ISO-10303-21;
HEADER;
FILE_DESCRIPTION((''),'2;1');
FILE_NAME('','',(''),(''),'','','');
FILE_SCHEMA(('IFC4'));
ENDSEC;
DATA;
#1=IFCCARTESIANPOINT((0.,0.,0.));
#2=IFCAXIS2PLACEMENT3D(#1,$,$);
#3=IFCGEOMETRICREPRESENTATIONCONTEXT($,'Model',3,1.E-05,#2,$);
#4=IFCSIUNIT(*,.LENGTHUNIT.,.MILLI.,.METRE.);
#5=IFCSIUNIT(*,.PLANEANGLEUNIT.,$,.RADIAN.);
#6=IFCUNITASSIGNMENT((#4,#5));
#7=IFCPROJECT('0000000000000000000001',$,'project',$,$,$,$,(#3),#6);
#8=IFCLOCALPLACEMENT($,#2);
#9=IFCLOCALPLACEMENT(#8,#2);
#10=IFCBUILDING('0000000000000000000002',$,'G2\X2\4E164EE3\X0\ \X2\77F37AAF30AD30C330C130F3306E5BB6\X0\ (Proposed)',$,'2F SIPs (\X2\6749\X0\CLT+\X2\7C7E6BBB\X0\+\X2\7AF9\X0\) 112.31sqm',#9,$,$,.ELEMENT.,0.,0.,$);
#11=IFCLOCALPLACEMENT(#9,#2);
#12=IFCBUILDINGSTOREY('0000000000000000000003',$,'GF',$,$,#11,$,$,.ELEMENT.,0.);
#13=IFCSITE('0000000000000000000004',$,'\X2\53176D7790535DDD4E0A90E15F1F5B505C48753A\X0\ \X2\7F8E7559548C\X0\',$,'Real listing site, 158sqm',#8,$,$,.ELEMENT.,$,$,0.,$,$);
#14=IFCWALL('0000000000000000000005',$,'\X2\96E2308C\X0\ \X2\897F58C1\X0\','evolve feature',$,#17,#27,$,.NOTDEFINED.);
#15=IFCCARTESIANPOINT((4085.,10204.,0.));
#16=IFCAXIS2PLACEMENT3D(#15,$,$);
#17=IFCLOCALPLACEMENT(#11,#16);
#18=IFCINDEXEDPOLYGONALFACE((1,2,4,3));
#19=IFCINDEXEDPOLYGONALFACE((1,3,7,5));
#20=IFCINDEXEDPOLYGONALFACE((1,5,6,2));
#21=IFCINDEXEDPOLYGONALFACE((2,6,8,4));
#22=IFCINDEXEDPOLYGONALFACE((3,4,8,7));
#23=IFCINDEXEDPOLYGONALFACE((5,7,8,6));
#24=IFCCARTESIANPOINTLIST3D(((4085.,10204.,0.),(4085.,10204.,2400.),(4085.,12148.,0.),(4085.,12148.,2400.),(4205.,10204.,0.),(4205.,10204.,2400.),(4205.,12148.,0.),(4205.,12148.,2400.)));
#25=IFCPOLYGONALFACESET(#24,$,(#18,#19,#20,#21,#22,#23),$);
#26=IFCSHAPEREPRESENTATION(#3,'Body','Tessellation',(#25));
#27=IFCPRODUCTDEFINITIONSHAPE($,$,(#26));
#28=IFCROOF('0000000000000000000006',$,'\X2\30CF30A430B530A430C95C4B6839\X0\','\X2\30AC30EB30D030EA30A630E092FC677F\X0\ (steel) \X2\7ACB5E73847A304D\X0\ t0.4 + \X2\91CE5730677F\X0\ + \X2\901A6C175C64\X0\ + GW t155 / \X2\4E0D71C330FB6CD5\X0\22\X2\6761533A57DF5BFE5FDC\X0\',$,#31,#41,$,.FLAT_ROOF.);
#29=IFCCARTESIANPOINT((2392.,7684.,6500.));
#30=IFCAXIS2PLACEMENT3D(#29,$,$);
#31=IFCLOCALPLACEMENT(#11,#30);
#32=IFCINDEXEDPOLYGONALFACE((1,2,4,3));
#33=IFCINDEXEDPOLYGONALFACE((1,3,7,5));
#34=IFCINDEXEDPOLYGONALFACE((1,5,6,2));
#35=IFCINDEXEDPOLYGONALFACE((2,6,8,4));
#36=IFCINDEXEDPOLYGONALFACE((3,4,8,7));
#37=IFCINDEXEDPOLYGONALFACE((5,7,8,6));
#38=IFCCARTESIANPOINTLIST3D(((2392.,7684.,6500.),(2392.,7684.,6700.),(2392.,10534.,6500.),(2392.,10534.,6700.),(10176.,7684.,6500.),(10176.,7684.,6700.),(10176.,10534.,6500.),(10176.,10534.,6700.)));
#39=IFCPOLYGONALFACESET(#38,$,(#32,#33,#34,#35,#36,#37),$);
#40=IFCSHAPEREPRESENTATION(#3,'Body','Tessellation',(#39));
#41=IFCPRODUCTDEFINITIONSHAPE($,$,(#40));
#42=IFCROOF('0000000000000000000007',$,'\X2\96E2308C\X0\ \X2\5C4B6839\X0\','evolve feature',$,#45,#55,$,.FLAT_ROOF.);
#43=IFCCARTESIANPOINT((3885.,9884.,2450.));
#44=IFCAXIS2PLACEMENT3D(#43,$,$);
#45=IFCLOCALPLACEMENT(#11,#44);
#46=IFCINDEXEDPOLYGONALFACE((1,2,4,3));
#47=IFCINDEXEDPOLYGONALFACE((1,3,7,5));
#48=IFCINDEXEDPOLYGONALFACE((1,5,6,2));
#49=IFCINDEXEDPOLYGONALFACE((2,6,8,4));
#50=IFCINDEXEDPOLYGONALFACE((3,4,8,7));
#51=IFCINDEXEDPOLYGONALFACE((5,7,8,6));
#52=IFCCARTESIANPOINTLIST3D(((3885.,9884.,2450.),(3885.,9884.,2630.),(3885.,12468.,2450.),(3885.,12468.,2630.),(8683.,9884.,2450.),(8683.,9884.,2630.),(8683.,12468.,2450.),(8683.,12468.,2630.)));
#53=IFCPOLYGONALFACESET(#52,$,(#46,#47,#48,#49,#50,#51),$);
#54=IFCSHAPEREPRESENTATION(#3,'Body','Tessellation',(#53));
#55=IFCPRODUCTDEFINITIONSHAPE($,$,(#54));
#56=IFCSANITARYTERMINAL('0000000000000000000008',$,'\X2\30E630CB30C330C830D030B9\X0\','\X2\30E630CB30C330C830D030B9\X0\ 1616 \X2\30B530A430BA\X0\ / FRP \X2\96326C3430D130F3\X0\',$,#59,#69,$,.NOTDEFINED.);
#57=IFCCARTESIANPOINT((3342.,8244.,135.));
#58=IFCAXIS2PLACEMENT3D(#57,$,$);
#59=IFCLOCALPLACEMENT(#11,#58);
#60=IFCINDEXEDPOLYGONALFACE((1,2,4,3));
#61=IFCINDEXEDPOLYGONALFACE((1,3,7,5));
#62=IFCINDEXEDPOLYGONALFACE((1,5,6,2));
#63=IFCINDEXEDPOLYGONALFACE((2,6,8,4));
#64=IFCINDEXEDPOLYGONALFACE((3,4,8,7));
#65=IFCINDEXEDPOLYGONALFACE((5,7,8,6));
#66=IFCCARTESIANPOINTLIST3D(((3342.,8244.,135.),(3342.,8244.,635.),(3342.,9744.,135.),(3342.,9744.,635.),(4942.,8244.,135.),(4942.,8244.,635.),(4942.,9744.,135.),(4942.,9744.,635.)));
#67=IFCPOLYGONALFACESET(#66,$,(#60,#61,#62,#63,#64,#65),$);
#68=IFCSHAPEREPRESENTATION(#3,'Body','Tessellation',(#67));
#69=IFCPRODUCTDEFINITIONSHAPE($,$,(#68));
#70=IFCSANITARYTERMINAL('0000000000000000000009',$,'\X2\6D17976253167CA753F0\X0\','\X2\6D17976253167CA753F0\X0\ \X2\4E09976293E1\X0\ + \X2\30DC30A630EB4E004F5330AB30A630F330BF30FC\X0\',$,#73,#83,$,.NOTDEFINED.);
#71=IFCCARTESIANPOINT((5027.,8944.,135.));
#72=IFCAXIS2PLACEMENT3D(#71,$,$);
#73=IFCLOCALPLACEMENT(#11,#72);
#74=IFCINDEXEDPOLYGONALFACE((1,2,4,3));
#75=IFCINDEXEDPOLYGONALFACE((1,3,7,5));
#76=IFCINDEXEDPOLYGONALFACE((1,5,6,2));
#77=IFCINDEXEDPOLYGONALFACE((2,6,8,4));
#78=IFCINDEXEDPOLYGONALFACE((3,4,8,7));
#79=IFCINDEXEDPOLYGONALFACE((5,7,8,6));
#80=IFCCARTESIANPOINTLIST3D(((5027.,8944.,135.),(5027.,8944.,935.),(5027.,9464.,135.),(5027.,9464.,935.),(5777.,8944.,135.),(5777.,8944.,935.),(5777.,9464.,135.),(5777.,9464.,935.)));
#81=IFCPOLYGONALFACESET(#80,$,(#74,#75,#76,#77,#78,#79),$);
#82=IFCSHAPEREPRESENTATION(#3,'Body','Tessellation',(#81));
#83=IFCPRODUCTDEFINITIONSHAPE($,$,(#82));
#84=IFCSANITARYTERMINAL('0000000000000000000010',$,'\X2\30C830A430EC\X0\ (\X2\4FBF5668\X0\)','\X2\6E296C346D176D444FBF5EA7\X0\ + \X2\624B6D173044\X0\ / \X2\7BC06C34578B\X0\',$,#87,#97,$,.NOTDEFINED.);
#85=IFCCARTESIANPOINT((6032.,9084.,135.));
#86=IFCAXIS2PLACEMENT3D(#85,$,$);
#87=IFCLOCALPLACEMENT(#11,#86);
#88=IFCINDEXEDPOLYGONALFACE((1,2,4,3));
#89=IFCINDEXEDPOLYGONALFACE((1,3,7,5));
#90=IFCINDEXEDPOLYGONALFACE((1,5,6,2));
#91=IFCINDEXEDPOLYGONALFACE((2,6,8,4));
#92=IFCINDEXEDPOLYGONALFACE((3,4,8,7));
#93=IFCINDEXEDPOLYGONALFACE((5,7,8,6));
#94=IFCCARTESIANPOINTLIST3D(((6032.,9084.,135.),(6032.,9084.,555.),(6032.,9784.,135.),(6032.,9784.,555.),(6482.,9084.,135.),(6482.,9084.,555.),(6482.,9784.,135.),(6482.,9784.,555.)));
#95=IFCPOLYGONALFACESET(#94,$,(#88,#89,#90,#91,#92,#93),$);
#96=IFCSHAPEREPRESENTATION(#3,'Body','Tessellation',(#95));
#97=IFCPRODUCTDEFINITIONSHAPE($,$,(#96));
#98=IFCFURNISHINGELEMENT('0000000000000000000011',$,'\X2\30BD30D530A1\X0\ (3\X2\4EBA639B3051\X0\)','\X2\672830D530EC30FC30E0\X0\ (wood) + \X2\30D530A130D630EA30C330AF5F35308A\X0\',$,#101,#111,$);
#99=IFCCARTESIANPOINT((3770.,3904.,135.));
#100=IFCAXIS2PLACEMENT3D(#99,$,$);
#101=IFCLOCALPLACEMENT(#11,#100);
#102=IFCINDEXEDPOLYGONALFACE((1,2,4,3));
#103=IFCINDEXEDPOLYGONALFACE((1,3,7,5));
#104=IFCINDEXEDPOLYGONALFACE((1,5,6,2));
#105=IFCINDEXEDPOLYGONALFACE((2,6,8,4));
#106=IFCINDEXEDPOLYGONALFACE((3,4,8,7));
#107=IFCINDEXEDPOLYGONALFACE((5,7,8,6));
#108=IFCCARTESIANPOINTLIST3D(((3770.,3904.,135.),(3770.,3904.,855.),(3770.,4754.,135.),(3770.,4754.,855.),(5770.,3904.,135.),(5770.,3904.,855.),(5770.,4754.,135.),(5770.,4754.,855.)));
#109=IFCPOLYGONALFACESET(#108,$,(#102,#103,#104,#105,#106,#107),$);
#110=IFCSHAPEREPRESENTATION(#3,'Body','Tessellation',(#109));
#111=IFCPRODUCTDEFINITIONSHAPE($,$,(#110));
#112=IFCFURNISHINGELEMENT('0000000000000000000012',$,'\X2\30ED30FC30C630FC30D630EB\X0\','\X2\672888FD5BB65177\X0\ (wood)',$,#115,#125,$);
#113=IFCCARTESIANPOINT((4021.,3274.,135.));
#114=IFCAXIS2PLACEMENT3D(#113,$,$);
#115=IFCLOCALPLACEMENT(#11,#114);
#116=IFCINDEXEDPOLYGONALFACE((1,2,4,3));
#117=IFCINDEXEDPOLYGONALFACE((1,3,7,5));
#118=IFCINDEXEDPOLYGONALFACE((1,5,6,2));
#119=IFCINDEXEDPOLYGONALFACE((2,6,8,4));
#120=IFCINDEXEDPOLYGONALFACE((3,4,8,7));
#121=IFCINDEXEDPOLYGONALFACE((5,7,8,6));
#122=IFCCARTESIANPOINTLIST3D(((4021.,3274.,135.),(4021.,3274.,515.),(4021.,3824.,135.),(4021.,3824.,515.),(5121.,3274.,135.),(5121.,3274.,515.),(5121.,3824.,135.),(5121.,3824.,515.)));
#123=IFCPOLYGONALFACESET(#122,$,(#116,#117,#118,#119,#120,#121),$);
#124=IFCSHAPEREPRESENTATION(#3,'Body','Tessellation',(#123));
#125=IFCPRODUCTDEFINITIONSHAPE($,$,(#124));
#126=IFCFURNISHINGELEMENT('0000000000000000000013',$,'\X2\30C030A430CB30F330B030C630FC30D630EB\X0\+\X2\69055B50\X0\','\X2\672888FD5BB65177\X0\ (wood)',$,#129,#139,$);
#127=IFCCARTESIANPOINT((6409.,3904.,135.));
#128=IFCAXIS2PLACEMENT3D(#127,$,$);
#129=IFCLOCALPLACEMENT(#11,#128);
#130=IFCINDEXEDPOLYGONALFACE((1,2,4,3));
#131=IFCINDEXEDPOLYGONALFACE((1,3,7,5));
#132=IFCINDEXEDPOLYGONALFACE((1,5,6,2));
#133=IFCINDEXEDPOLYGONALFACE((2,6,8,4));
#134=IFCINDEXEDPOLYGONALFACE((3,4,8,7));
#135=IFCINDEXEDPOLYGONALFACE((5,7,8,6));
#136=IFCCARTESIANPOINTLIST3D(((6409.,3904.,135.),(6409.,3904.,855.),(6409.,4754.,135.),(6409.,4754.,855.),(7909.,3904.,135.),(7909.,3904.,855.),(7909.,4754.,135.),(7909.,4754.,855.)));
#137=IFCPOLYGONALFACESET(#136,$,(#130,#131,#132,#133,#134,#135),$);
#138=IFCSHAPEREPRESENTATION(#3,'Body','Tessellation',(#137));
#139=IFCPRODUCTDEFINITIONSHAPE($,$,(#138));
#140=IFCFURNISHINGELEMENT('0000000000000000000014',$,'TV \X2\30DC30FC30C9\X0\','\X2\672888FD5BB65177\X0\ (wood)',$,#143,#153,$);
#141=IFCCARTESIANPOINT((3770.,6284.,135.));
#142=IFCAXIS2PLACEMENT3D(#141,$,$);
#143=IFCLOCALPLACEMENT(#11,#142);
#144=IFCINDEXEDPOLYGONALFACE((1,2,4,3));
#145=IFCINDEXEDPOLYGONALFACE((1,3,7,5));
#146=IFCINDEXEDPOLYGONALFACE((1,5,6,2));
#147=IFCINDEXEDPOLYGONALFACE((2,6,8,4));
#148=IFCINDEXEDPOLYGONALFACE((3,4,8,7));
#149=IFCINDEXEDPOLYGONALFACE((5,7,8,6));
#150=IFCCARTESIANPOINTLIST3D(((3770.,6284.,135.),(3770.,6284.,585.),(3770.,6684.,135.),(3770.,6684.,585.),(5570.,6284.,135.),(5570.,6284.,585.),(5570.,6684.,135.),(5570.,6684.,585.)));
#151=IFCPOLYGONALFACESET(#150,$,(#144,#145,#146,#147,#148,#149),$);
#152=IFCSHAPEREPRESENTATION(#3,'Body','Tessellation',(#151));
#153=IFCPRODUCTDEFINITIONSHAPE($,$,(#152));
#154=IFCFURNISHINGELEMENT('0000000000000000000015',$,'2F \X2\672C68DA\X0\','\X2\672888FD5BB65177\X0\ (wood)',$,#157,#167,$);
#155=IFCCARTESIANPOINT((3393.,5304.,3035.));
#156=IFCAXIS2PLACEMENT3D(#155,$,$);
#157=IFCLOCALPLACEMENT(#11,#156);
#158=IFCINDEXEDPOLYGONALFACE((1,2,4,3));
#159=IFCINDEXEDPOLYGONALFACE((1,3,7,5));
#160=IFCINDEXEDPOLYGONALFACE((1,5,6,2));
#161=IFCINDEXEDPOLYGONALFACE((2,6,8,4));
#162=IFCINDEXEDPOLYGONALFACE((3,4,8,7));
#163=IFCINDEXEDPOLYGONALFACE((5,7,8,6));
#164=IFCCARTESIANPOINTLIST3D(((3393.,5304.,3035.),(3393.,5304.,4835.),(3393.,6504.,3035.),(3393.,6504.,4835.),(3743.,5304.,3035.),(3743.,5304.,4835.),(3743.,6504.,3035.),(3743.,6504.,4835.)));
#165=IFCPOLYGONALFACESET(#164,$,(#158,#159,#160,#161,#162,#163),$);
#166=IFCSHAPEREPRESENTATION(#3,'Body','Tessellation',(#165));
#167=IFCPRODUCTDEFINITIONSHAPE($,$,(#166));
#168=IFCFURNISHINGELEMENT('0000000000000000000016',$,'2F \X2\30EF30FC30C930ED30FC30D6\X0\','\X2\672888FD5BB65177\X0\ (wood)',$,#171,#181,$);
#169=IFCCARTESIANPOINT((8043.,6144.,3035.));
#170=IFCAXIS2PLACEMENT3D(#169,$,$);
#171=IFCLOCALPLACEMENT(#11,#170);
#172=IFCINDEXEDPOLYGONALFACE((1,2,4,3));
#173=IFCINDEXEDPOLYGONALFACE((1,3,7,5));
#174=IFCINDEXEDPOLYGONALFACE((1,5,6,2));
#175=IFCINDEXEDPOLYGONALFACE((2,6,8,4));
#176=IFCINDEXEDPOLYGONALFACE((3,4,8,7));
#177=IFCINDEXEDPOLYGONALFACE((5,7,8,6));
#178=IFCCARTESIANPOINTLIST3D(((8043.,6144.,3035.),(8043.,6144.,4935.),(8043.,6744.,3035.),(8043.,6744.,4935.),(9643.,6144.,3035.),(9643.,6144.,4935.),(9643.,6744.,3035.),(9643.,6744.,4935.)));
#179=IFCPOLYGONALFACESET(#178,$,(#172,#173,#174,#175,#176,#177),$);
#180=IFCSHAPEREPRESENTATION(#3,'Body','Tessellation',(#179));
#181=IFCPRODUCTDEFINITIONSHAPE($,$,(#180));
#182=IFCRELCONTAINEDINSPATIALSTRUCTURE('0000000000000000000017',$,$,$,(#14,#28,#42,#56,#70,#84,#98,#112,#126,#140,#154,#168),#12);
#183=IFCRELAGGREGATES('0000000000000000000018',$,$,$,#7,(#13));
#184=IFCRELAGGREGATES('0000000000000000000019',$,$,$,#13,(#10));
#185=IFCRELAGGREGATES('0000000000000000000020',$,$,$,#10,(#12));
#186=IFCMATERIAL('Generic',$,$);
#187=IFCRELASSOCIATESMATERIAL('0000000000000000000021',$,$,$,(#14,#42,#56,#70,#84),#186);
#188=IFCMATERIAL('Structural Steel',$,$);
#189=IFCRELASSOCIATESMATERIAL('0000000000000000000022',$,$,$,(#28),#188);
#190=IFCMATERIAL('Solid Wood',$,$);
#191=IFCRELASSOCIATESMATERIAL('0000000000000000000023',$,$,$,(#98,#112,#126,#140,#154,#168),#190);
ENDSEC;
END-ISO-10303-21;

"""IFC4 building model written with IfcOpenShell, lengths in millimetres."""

from ifc_helpers import new_model, si_unit, frame, frame_2d, origin, place, context, project, spatial, rectangle, extrude, material, element, save


model = new_model("IFC4")

# Units and contexts
model_context = context("Model", 3, precision=1e-05, world=origin())
ifc_project = project(units=[si_unit("LENGTHUNIT", "METRE", prefix="MILLI"), si_unit("PLANEANGLEUNIT", "RADIAN")], contexts=[model_context])

# Site, building, storey
site_placement = place(None, origin())
site = spatial("IfcSite", under=ifc_project, at=site_placement, Name="北海道川上郡弟子屈町 美留和", ObjectType="Real listing site, 158sqm", CompositionType="ELEMENT", RefElevation=0.0)
building_placement = place(site_placement, origin())
building = spatial("IfcBuilding", under=site, at=building_placement, Name="G2世代 石窯キッチンの家 (Proposed)", ObjectType="2F SIPs (杉CLT+籾殻+竹) 112.31sqm", CompositionType="ELEMENT", ElevationOfRefHeight=0.0, ElevationOfTerrain=0.0)
storey_placement = place(building_placement, origin())
storey = spatial("IfcBuildingStorey", under=building, at=storey_placement, Name="GF", CompositionType="ELEMENT", Elevation=0.0)

# Shared definitions
ifc_material_1 = material(Name="Generic")

# Shared definitions
ifc_material_2 = material(Name="Solid Wood")

# Wall
wall_1_placement = place(storey_placement, frame((4085.0, 10204.0, 0.0)))
element("IfcWall", 1, at=wall_1_placement, inside=storey, material=ifc_material_1, Name="離れ 西壁", Description="evolve feature", PredefinedType="NOTDEFINED", context=model_context, shape_type="SweptSolid", body=[
    extrude(rectangle(XDim=120.0, YDim=1944.0, at=frame_2d((60.0, 972.0))), frame((4085.0, 10204.0, 0.0)), (0.0, 0.0, 1.0), 2400.0),
])

# Roofs
ifc_material_3 = material(Name="Structural Steel")
roof_1_placement = place(storey_placement, frame((2392.0, 7684.0, 6500.0)))
element("IfcRoof", 2, at=roof_1_placement, inside=storey, material=ifc_material_3, Name="ハイサイド屋根", Description="ガルバリウム鋼板 (steel) 立平葺き t0.4 + 野地板 + 通気層 + GW t155 / 不燃・法22条区域対応", PredefinedType="FLAT_ROOF", context=model_context, shape_type="SweptSolid", body=[
    extrude(rectangle(XDim=7784.0, YDim=2850.0, at=frame_2d((3892.0, 1425.0))), frame((2392.0, 7684.0, 6500.0)), (0.0, 0.0, 1.0), 200.0),
])
roof_2_placement = place(storey_placement, frame((3885.0, 9884.0, 2450.0)))
element("IfcRoof", 3, at=roof_2_placement, inside=storey, material=ifc_material_1, Name="離れ 屋根", Description="evolve feature", PredefinedType="FLAT_ROOF", context=model_context, shape_type="SweptSolid", body=[
    extrude(rectangle(XDim=4798.0, YDim=2584.0, at=frame_2d((2399.0, 1292.0))), frame((3885.0, 9884.0, 2450.0)), (0.0, 0.0, 1.0), 180.0),
])

# Sanitary terminals
sanitary_terminal_1_placement = place(storey_placement, frame((3342.0, 8244.0, 135.0)))
element("IfcSanitaryTerminal", 4, at=sanitary_terminal_1_placement, inside=storey, material=ifc_material_1, Name="ユニットバス", Description="ユニットバス 1616 サイズ / FRP 防水パン", PredefinedType="NOTDEFINED", context=model_context, shape_type="SweptSolid", body=[
    extrude(rectangle(XDim=1600.0, YDim=1500.0, at=frame_2d((800.0, 750.0))), frame((3342.0, 8244.0, 135.0)), (0.0, 0.0, 1.0), 500.0),
])
sanitary_terminal_2_placement = place(storey_placement, frame((5027.0, 8944.0, 135.0)))
element("IfcSanitaryTerminal", 5, at=sanitary_terminal_2_placement, inside=storey, material=ifc_material_1, Name="洗面化粧台", Description="洗面化粧台 三面鏡 + ボウル一体カウンター", PredefinedType="NOTDEFINED", context=model_context, shape_type="SweptSolid", body=[
    extrude(rectangle(XDim=750.0, YDim=520.0, at=frame_2d((375.0, 260.0))), frame((5027.0, 8944.0, 135.0)), (0.0, 0.0, 1.0), 800.0),
])
sanitary_terminal_3_placement = place(storey_placement, frame((6032.0, 9084.0, 135.0)))
element("IfcSanitaryTerminal", 6, at=sanitary_terminal_3_placement, inside=storey, material=ifc_material_1, Name="トイレ (便器)", Description="温水洗浄便座 + 手洗い / 節水型", PredefinedType="NOTDEFINED", context=model_context, shape_type="SweptSolid", body=[
    extrude(rectangle(XDim=450.0, YDim=700.0, at=frame_2d((225.0, 350.0))), frame((6032.0, 9084.0, 135.0)), (0.0, 0.0, 1.0), 420.0),
])

# Furnishing elements
furnishing_1_placement = place(storey_placement, frame((3770.0, 3904.0, 135.0)))
element("IfcFurnishingElement", 7, at=furnishing_1_placement, inside=storey, material=ifc_material_2, Name="ソファ (3人掛け)", Description="木フレーム (wood) + ファブリック張り", context=model_context, shape_type="SweptSolid", body=[
    extrude(rectangle(XDim=2000.0, YDim=850.0, at=frame_2d((1000.0, 425.0))), frame((3770.0, 3904.0, 135.0)), (0.0, 0.0, 1.0), 720.0),
])
furnishing_2_placement = place(storey_placement, frame((4021.0, 3274.0, 135.0)))
element("IfcFurnishingElement", 8, at=furnishing_2_placement, inside=storey, material=ifc_material_2, Name="ローテーブル", Description="木製家具 (wood)", context=model_context, shape_type="SweptSolid", body=[
    extrude(rectangle(XDim=1100.0, YDim=550.0, at=frame_2d((550.0, 275.0))), frame((4021.0, 3274.0, 135.0)), (0.0, 0.0, 1.0), 380.0),
])
furnishing_3_placement = place(storey_placement, frame((6409.0, 3904.0, 135.0)))
element("IfcFurnishingElement", 9, at=furnishing_3_placement, inside=storey, material=ifc_material_2, Name="ダイニングテーブル+椅子", Description="木製家具 (wood)", context=model_context, shape_type="SweptSolid", body=[
    extrude(rectangle(XDim=1500.0, YDim=850.0, at=frame_2d((750.0, 425.0))), frame((6409.0, 3904.0, 135.0)), (0.0, 0.0, 1.0), 720.0),
])
furnishing_4_placement = place(storey_placement, frame((3770.0, 6284.0, 135.0)))
element("IfcFurnishingElement", 10, at=furnishing_4_placement, inside=storey, material=ifc_material_2, Name="TV ボード", Description="木製家具 (wood)", context=model_context, shape_type="SweptSolid", body=[
    extrude(rectangle(XDim=1800.0, YDim=400.0, at=frame_2d((900.0, 200.0))), frame((3770.0, 6284.0, 135.0)), (0.0, 0.0, 1.0), 450.0),
])
furnishing_5_placement = place(storey_placement, frame((3393.0, 5304.0, 3035.0)))
element("IfcFurnishingElement", 11, at=furnishing_5_placement, inside=storey, material=ifc_material_2, Name="2F 本棚", Description="木製家具 (wood)", context=model_context, shape_type="SweptSolid", body=[
    extrude(rectangle(XDim=350.0, YDim=1200.0, at=frame_2d((175.0, 600.0))), frame((3393.0, 5304.0, 3035.0)), (0.0, 0.0, 1.0), 1800.0),
])
furnishing_6_placement = place(storey_placement, frame((8043.0, 6144.0, 3035.0)))
element("IfcFurnishingElement", 12, at=furnishing_6_placement, inside=storey, material=ifc_material_2, Name="2F ワードローブ", Description="木製家具 (wood)", context=model_context, shape_type="SweptSolid", body=[
    extrude(rectangle(XDim=1600.0, YDim=600.0, at=frame_2d((800.0, 300.0))), frame((8043.0, 6144.0, 3035.0)), (0.0, 0.0, 1.0), 1900.0),
])

save(model, "model.ifc")
